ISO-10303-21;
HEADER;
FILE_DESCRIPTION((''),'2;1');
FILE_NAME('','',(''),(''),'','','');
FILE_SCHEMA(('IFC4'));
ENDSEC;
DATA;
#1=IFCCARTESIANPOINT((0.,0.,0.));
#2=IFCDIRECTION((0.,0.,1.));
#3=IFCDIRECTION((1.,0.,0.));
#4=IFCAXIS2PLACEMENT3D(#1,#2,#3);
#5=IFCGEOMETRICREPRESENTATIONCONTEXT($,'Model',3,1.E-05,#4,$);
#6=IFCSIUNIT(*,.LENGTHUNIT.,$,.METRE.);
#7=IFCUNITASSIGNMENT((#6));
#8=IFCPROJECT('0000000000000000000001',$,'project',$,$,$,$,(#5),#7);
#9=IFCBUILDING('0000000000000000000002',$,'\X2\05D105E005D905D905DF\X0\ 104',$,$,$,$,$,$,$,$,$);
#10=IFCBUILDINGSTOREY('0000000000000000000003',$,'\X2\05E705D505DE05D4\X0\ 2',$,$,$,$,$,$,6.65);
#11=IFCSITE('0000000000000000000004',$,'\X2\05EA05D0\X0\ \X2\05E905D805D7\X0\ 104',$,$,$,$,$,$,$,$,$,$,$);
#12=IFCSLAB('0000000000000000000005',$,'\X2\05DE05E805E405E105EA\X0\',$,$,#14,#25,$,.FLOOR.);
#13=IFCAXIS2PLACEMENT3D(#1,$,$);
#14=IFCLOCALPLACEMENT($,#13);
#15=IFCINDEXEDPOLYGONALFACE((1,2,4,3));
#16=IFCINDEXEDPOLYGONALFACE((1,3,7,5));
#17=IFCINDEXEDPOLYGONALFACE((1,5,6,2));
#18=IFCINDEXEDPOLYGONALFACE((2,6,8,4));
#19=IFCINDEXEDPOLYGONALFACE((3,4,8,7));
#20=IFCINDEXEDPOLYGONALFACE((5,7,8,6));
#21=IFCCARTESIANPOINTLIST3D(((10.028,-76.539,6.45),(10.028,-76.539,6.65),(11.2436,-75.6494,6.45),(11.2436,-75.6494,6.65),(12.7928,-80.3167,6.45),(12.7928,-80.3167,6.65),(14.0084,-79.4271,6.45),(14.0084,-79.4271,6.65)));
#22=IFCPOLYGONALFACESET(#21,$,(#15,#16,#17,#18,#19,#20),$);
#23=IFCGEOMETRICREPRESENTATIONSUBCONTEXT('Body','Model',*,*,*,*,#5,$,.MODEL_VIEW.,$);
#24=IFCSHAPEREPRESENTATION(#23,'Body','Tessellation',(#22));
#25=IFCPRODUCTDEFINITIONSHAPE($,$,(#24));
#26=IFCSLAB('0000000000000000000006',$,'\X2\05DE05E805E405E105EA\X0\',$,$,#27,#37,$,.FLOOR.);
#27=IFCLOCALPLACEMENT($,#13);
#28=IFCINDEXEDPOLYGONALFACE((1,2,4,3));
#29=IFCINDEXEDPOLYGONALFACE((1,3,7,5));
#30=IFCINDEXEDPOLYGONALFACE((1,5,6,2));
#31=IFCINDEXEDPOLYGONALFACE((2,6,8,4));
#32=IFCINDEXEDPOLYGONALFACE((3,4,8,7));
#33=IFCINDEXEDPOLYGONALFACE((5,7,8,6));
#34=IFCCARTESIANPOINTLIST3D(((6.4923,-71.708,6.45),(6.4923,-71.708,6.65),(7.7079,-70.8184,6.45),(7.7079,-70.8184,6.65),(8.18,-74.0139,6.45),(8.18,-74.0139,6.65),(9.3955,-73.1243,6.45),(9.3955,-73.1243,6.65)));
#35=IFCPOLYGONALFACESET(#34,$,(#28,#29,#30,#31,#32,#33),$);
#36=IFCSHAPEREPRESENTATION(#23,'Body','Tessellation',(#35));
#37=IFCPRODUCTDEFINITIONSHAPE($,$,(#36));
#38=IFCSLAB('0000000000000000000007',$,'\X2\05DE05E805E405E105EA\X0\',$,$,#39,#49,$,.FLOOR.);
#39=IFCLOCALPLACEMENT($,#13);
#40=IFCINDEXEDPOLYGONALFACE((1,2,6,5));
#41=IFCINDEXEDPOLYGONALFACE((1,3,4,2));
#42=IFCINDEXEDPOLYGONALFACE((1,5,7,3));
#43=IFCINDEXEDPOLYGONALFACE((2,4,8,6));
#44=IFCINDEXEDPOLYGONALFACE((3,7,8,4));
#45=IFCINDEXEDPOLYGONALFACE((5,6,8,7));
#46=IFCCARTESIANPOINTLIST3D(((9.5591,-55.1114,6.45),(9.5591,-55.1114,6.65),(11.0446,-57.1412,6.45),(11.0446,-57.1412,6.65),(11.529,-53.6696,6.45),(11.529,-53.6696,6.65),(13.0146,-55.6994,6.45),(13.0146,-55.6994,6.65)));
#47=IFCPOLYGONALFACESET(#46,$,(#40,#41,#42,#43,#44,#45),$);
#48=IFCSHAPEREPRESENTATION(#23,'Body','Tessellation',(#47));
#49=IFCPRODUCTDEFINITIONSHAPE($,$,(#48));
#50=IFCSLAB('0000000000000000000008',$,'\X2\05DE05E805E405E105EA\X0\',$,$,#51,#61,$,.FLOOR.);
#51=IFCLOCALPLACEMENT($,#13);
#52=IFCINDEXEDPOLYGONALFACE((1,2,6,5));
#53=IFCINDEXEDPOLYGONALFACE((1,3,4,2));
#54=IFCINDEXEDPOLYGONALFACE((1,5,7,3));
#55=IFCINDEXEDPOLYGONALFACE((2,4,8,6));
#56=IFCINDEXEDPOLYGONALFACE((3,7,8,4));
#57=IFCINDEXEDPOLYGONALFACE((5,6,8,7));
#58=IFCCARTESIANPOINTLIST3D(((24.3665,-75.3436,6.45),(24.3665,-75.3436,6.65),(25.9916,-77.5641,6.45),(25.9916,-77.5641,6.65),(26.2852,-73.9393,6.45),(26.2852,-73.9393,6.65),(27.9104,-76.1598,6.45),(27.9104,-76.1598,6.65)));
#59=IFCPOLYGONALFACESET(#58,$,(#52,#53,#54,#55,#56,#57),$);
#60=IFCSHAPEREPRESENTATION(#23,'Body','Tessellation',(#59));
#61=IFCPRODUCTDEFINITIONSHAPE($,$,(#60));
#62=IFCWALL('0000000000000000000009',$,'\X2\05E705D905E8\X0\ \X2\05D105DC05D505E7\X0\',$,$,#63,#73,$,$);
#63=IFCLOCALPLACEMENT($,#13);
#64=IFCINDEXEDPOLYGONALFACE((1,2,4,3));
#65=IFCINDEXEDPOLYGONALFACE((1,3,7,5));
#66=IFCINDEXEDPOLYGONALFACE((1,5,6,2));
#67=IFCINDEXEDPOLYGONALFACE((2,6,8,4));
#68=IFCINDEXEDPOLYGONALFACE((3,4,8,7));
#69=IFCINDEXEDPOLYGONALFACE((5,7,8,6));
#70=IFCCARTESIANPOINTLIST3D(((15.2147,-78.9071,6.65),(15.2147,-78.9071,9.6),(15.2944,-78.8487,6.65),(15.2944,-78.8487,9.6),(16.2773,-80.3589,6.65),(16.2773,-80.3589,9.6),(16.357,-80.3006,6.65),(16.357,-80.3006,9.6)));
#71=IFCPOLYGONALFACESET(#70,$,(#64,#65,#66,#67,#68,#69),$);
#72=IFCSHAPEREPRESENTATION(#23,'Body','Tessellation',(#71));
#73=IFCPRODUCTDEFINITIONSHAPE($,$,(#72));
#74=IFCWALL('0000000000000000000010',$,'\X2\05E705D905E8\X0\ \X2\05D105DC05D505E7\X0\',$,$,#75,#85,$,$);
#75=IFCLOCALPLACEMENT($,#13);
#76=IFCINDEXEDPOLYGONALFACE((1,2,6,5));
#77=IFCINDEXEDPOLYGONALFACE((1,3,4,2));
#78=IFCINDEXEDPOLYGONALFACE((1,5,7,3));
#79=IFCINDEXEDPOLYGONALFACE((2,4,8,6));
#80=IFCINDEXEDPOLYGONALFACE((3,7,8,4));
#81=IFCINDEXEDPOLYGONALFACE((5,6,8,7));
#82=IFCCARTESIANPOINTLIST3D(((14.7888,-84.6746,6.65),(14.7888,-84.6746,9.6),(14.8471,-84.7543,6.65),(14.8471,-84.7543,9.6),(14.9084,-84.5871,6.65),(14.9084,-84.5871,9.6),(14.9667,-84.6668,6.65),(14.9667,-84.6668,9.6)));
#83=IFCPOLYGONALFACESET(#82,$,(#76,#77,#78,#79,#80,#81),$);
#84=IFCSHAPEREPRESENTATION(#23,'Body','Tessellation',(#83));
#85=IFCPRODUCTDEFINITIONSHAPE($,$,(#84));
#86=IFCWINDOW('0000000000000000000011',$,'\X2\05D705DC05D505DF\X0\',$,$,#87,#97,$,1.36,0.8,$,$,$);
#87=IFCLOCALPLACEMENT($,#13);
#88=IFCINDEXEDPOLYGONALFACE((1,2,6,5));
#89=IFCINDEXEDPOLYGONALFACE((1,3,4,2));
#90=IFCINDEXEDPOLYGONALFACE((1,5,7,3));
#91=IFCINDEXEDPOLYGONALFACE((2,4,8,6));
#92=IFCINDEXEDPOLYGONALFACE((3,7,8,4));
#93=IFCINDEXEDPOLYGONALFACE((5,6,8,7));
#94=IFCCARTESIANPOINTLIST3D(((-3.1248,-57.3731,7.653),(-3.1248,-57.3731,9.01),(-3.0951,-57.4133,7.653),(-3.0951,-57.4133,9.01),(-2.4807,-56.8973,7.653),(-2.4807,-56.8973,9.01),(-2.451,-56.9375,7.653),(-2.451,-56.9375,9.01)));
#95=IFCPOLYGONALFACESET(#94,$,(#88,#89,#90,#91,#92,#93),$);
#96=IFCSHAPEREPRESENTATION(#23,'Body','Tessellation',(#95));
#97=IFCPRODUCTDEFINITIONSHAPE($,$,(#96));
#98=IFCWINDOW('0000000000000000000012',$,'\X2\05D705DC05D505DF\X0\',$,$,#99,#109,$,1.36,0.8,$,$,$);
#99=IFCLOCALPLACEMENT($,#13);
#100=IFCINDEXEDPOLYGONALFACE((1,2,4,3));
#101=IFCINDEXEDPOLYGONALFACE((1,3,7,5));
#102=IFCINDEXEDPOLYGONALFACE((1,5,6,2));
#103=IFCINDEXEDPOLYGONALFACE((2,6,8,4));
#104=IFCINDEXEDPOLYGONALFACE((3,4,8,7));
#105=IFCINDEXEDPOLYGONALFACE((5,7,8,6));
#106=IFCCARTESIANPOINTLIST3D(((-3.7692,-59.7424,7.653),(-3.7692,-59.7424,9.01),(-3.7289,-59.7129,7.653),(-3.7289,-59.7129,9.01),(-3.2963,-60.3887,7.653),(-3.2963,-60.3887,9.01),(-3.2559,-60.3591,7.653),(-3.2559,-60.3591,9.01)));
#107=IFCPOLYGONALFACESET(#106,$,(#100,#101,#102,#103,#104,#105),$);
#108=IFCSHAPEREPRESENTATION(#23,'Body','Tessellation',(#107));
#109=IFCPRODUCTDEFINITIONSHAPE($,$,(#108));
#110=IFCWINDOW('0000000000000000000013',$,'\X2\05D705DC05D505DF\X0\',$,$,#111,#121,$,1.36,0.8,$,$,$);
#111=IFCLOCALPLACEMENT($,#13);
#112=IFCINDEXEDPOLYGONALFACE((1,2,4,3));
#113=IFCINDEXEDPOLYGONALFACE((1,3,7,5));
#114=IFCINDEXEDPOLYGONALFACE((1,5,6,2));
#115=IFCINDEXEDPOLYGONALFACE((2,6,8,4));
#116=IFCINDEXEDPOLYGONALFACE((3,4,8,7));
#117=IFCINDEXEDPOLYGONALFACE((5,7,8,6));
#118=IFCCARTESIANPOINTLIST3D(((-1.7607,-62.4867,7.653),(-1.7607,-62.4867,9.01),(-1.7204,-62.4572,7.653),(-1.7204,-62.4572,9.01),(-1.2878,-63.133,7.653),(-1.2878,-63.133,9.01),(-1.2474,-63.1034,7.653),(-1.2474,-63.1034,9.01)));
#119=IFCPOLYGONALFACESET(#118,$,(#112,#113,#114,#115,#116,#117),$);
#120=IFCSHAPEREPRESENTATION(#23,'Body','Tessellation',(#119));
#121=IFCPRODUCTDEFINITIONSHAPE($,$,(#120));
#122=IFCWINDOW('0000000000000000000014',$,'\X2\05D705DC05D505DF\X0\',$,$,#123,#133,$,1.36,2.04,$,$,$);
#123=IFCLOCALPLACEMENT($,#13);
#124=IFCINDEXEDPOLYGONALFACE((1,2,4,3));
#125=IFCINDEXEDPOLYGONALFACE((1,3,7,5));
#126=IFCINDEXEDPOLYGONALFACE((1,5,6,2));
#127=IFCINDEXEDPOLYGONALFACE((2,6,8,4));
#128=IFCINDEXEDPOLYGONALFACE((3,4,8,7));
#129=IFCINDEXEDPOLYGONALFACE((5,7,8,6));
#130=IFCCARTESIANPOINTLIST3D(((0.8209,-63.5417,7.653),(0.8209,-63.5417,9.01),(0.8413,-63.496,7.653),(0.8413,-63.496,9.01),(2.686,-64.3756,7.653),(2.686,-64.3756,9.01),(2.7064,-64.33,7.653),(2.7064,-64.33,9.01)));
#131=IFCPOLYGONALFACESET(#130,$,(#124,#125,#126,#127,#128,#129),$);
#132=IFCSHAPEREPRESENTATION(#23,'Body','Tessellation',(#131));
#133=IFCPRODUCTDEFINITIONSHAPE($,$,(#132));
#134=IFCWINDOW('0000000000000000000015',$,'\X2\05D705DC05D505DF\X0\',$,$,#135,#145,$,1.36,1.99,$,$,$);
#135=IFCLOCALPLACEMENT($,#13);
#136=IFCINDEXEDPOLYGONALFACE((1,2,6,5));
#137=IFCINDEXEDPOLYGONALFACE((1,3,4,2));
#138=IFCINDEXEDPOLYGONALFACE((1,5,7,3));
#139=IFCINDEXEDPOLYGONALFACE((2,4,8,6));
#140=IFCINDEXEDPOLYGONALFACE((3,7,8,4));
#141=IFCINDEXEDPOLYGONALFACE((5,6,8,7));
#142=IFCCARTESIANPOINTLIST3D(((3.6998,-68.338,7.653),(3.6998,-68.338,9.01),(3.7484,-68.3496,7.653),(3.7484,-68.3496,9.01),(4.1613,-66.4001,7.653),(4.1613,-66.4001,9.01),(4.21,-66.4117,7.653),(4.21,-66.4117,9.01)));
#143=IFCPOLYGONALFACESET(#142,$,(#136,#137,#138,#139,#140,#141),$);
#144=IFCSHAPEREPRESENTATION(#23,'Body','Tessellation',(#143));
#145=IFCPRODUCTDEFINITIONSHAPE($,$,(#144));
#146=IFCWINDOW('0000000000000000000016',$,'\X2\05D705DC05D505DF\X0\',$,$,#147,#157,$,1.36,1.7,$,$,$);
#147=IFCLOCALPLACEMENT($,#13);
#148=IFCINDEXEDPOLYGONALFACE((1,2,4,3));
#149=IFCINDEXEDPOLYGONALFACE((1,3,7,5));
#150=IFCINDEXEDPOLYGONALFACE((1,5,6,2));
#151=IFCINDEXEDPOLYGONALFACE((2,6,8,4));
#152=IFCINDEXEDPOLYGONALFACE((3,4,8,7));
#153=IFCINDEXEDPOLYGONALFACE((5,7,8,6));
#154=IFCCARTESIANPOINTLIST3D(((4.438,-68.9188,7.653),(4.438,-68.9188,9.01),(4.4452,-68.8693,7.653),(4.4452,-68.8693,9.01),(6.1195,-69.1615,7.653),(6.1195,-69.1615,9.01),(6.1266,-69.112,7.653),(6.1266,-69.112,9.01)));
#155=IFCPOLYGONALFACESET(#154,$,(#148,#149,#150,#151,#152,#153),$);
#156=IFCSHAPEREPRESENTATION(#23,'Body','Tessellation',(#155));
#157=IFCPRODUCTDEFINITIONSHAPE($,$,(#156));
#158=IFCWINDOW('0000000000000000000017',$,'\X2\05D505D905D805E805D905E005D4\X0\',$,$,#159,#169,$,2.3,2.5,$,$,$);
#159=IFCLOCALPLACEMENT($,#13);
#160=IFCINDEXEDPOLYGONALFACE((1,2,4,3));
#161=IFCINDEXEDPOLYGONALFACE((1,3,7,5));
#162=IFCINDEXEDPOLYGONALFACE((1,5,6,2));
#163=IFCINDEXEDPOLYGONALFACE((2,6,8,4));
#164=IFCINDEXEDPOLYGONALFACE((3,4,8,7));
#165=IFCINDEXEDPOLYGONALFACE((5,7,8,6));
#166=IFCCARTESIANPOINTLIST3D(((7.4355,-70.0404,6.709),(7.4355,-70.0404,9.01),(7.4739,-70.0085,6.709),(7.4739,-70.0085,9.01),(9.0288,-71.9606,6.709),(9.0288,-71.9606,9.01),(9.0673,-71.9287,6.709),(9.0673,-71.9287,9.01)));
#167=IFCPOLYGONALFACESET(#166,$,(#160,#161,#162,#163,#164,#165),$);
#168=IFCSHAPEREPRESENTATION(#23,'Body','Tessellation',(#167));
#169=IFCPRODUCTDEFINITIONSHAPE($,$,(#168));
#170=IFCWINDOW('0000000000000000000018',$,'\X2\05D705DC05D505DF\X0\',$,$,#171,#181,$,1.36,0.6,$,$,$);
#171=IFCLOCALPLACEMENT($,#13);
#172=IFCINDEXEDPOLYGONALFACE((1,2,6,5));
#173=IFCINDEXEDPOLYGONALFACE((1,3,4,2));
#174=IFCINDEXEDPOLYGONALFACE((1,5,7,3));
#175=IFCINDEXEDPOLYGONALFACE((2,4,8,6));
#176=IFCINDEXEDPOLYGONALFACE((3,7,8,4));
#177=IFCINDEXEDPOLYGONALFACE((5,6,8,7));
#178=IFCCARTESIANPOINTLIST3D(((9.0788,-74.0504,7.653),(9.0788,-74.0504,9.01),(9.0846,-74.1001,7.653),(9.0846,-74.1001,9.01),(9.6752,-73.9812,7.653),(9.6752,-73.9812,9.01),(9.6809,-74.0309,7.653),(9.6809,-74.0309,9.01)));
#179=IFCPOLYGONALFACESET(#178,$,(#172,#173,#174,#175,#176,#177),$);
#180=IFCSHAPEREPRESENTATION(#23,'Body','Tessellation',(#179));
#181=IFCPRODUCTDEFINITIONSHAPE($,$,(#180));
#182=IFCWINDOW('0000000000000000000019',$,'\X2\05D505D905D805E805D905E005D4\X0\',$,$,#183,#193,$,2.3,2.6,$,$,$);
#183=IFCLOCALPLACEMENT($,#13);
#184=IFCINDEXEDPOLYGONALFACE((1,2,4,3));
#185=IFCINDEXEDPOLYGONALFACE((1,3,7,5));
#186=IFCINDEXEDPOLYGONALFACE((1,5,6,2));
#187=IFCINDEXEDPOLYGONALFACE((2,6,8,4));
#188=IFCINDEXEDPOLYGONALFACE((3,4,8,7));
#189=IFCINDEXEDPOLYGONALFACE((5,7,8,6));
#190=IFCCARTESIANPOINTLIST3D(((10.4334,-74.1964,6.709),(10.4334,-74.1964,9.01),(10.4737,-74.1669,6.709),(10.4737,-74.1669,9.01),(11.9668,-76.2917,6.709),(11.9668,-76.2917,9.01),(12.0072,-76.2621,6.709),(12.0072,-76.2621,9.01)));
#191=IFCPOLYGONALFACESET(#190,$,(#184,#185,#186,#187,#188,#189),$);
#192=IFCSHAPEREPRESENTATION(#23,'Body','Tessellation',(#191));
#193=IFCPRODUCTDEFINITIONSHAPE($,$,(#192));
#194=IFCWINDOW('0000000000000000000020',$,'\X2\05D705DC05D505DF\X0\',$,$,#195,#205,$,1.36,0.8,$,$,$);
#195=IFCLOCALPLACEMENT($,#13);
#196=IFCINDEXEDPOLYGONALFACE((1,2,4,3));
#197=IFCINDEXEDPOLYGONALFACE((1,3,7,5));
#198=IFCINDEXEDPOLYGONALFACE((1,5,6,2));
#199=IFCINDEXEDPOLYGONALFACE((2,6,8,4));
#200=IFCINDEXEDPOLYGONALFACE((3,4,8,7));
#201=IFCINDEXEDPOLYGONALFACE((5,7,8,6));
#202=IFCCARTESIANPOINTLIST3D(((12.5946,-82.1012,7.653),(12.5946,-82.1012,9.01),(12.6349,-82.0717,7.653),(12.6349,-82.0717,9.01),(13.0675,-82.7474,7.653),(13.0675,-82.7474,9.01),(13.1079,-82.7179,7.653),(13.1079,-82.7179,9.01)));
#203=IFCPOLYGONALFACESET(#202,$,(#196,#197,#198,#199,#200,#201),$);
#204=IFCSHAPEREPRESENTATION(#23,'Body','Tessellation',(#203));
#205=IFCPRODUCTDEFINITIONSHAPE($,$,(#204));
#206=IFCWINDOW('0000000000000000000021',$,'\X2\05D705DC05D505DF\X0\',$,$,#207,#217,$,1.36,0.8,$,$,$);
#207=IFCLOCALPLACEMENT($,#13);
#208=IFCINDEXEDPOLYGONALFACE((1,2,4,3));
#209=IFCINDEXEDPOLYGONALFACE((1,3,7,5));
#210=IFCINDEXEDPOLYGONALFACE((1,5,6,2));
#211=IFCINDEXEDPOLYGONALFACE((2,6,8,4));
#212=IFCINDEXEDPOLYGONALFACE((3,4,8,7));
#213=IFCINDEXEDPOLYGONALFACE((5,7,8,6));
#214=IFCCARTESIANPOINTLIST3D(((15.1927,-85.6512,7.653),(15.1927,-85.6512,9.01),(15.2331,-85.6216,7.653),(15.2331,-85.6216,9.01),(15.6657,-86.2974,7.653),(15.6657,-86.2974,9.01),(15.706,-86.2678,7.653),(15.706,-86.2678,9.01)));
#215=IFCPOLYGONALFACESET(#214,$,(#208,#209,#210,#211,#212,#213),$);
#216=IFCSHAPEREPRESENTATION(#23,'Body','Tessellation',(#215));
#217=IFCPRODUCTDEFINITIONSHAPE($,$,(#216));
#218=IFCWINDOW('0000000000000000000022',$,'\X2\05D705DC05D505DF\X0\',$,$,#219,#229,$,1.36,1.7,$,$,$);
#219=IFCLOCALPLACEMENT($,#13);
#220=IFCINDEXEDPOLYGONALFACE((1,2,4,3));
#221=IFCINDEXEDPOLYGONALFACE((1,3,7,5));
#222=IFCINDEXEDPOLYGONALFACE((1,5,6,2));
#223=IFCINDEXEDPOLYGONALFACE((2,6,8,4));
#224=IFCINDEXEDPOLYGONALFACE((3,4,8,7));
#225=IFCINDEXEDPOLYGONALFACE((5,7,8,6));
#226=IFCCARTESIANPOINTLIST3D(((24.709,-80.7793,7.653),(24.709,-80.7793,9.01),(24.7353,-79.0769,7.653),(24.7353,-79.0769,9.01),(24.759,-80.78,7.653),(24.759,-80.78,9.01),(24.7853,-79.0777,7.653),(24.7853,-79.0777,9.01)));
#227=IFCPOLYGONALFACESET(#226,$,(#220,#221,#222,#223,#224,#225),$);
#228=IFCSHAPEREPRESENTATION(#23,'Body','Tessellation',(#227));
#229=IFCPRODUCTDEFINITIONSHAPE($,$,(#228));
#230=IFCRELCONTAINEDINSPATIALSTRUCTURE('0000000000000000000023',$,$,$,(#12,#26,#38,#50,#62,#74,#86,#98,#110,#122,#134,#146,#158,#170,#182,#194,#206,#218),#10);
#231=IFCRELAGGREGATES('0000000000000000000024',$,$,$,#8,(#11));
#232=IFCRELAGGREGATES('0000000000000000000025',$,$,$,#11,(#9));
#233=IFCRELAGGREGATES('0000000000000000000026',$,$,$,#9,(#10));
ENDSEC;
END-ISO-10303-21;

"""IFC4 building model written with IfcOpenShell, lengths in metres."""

from ifc_helpers import new_model, si_unit, frame, origin_with_axes, context, subcontext, project, spatial, polyline, outline, extrude, element, save


model = new_model("IFC4")

# Units and contexts
model_context = context("Model", 3, precision=1e-05, world=origin_with_axes())
body_context = subcontext(model_context, "Body", "Model", "MODEL_VIEW")
ifc_project = project(units=[si_unit("LENGTHUNIT", "METRE")], contexts=[model_context])

# Site, building, storey
site = spatial("IfcSite", under=ifc_project, Name="תא שטח 104")
building = spatial("IfcBuilding", under=site, Name="בניין 104")
storey = spatial("IfcBuildingStorey", under=building, Name="קומה 2", Elevation=6.65)

# Slabs
element("IfcSlab", 1, inside=storey, Name="מרפסת", PredefinedType="FLOOR", context=body_context, shape_type="SweptSolid", body=[
    extrude(outline(polyline([(11.2436, -75.6494), (14.0084, -79.4271), (12.7928, -80.3167), (10.028, -76.539), (11.2436, -75.6494)])), frame((0.0, 0.0, 6.45)), (0.0, 0.0, 1.0), 0.2),
])
element("IfcSlab", 2, inside=storey, Name="מרפסת", PredefinedType="FLOOR", context=body_context, shape_type="SweptSolid", body=[
    extrude(outline(polyline([(7.7079, -70.8184), (9.3955, -73.1243), (8.18, -74.0139), (6.4923, -71.708), (7.7079, -70.8184)])), frame((0.0, 0.0, 6.45)), (0.0, 0.0, 1.0), 0.2),
])
element("IfcSlab", 3, inside=storey, Name="מרפסת", PredefinedType="FLOOR", context=body_context, shape_type="SweptSolid", body=[
    extrude(outline(polyline([(11.529, -53.6696), (13.0146, -55.6994), (11.0446, -57.1412), (9.5591, -55.1114), (11.529, -53.6696)])), frame((0.0, 0.0, 6.45)), (0.0, 0.0, 1.0), 0.2),
])
element("IfcSlab", 4, inside=storey, Name="מרפסת", PredefinedType="FLOOR", context=body_context, shape_type="SweptSolid", body=[
    extrude(outline(polyline([(26.2852, -73.9393), (27.9104, -76.1598), (25.9916, -77.5641), (24.3665, -75.3436), (26.2852, -73.9393)])), frame((0.0, 0.0, 6.45)), (0.0, 0.0, 1.0), 0.2),
])

# Walls
element("IfcWall", 5, inside=storey, Name="קיר בלוק", context=body_context, shape_type="SweptSolid", body=[
    extrude(outline(polyline([(16.357, -80.3006), (15.2944, -78.8487), (15.2147, -78.9071), (16.2773, -80.3589), (16.357, -80.3006)])), frame((0.0, 0.0, 6.65)), (0.0, 0.0, 1.0), 2.95),
])
element("IfcWall", 6, inside=storey, Name="קיר בלוק", context=body_context, shape_type="SweptSolid", body=[
    extrude(outline(polyline([(14.7888, -84.6746), (14.8471, -84.7543), (14.9667, -84.6668), (14.9084, -84.5871), (14.7888, -84.6746)])), frame((0.0, 0.0, 6.65)), (0.0, 0.0, 1.0), 2.95),
])

# Windows
element("IfcWindow", 7, inside=storey, Name="חלון", OverallHeight=1.36, OverallWidth=0.8, context=body_context, shape_type="SweptSolid", body=[
    extrude(outline(polyline([(-2.4807, -56.8973), (-3.1248, -57.3731), (-3.0951, -57.4133), (-2.451, -56.9375), (-2.4807, -56.8973)])), frame((0.0, 0.0, 7.653)), (0.0, 0.0, 1.0), 1.357),
])
element("IfcWindow", 8, inside=storey, Name="חלון", OverallHeight=1.36, OverallWidth=0.8, context=body_context, shape_type="SweptSolid", body=[
    extrude(outline(polyline([(-3.7692, -59.7424), (-3.2963, -60.3887), (-3.2559, -60.3591), (-3.7289, -59.7129), (-3.7692, -59.7424)])), frame((0.0, 0.0, 7.653)), (0.0, 0.0, 1.0), 1.357),
])
element("IfcWindow", 9, inside=storey, Name="חלון", OverallHeight=1.36, OverallWidth=0.8, context=body_context, shape_type="SweptSolid", body=[
    extrude(outline(polyline([(-1.7607, -62.4867), (-1.2878, -63.133), (-1.2474, -63.1034), (-1.7204, -62.4572), (-1.7607, -62.4867)])), frame((0.0, 0.0, 7.653)), (0.0, 0.0, 1.0), 1.357),
])
element("IfcWindow", 10, inside=storey, Name="חלון", OverallHeight=1.36, OverallWidth=2.04, context=body_context, shape_type="SweptSolid", body=[
    extrude(outline(polyline([(0.8209, -63.5417), (2.686, -64.3756), (2.7064, -64.33), (0.8413, -63.496), (0.8209, -63.5417)])), frame((0.0, 0.0, 7.653)), (0.0, 0.0, 1.0), 1.357),
])
element("IfcWindow", 11, inside=storey, Name="חלון", OverallHeight=1.36, OverallWidth=1.99, context=body_context, shape_type="SweptSolid", body=[
    extrude(outline(polyline([(4.1613, -66.4001), (3.6998, -68.338), (3.7484, -68.3496), (4.21, -66.4117), (4.1613, -66.4001)])), frame((0.0, 0.0, 7.653)), (0.0, 0.0, 1.0), 1.357),
])
element("IfcWindow", 12, inside=storey, Name="חלון", OverallHeight=1.36, OverallWidth=1.7, context=body_context, shape_type="SweptSolid", body=[
    extrude(outline(polyline([(4.438, -68.9188), (6.1195, -69.1615), (6.1266, -69.112), (4.4452, -68.8693), (4.438, -68.9188)])), frame((0.0, 0.0, 7.653)), (0.0, 0.0, 1.0), 1.357),
])
element("IfcWindow", 13, inside=storey, Name="ויטרינה", OverallHeight=2.3, OverallWidth=2.5, context=body_context, shape_type="SweptSolid", body=[
    extrude(outline(polyline([(7.4355, -70.0404), (9.0288, -71.9606), (9.0673, -71.9287), (7.4739, -70.0085), (7.4355, -70.0404)])), frame((0.0, 0.0, 6.709)), (0.0, 0.0, 1.0), 2.301),
])
element("IfcWindow", 14, inside=storey, Name="חלון", OverallHeight=1.36, OverallWidth=0.6, context=body_context, shape_type="SweptSolid", body=[
    extrude(outline(polyline([(9.0846, -74.1001), (9.6809, -74.0309), (9.6752, -73.9812), (9.0788, -74.0504), (9.0846, -74.1001)])), frame((0.0, 0.0, 7.653)), (0.0, 0.0, 1.0), 1.357),
])
element("IfcWindow", 15, inside=storey, Name="ויטרינה", OverallHeight=2.3, OverallWidth=2.6, context=body_context, shape_type="SweptSolid", body=[
    extrude(outline(polyline([(10.4334, -74.1964), (11.9668, -76.2917), (12.0072, -76.2621), (10.4737, -74.1669), (10.4334, -74.1964)])), frame((0.0, 0.0, 6.709)), (0.0, 0.0, 1.0), 2.301),
])
element("IfcWindow", 16, inside=storey, Name="חלון", OverallHeight=1.36, OverallWidth=0.8, context=body_context, shape_type="SweptSolid", body=[
    extrude(outline(polyline([(12.5946, -82.1012), (13.0675, -82.7474), (13.1079, -82.7179), (12.6349, -82.0717), (12.5946, -82.1012)])), frame((0.0, 0.0, 7.653)), (0.0, 0.0, 1.0), 1.357),
])
element("IfcWindow", 17, inside=storey, Name="חלון", OverallHeight=1.36, OverallWidth=0.8, context=body_context, shape_type="SweptSolid", body=[
    extrude(outline(polyline([(15.1927, -85.6512), (15.6657, -86.2974), (15.706, -86.2678), (15.2331, -85.6216), (15.1927, -85.6512)])), frame((0.0, 0.0, 7.653)), (0.0, 0.0, 1.0), 1.357),
])
element("IfcWindow", 18, inside=storey, Name="חלון", OverallHeight=1.36, OverallWidth=1.7, context=body_context, shape_type="SweptSolid", body=[
    extrude(outline(polyline([(24.759, -80.78), (24.7853, -79.0777), (24.7353, -79.0769), (24.709, -80.7793), (24.759, -80.78)])), frame((0.0, 0.0, 7.653)), (0.0, 0.0, 1.0), 1.357),
])

save(model, "model.ifc")
